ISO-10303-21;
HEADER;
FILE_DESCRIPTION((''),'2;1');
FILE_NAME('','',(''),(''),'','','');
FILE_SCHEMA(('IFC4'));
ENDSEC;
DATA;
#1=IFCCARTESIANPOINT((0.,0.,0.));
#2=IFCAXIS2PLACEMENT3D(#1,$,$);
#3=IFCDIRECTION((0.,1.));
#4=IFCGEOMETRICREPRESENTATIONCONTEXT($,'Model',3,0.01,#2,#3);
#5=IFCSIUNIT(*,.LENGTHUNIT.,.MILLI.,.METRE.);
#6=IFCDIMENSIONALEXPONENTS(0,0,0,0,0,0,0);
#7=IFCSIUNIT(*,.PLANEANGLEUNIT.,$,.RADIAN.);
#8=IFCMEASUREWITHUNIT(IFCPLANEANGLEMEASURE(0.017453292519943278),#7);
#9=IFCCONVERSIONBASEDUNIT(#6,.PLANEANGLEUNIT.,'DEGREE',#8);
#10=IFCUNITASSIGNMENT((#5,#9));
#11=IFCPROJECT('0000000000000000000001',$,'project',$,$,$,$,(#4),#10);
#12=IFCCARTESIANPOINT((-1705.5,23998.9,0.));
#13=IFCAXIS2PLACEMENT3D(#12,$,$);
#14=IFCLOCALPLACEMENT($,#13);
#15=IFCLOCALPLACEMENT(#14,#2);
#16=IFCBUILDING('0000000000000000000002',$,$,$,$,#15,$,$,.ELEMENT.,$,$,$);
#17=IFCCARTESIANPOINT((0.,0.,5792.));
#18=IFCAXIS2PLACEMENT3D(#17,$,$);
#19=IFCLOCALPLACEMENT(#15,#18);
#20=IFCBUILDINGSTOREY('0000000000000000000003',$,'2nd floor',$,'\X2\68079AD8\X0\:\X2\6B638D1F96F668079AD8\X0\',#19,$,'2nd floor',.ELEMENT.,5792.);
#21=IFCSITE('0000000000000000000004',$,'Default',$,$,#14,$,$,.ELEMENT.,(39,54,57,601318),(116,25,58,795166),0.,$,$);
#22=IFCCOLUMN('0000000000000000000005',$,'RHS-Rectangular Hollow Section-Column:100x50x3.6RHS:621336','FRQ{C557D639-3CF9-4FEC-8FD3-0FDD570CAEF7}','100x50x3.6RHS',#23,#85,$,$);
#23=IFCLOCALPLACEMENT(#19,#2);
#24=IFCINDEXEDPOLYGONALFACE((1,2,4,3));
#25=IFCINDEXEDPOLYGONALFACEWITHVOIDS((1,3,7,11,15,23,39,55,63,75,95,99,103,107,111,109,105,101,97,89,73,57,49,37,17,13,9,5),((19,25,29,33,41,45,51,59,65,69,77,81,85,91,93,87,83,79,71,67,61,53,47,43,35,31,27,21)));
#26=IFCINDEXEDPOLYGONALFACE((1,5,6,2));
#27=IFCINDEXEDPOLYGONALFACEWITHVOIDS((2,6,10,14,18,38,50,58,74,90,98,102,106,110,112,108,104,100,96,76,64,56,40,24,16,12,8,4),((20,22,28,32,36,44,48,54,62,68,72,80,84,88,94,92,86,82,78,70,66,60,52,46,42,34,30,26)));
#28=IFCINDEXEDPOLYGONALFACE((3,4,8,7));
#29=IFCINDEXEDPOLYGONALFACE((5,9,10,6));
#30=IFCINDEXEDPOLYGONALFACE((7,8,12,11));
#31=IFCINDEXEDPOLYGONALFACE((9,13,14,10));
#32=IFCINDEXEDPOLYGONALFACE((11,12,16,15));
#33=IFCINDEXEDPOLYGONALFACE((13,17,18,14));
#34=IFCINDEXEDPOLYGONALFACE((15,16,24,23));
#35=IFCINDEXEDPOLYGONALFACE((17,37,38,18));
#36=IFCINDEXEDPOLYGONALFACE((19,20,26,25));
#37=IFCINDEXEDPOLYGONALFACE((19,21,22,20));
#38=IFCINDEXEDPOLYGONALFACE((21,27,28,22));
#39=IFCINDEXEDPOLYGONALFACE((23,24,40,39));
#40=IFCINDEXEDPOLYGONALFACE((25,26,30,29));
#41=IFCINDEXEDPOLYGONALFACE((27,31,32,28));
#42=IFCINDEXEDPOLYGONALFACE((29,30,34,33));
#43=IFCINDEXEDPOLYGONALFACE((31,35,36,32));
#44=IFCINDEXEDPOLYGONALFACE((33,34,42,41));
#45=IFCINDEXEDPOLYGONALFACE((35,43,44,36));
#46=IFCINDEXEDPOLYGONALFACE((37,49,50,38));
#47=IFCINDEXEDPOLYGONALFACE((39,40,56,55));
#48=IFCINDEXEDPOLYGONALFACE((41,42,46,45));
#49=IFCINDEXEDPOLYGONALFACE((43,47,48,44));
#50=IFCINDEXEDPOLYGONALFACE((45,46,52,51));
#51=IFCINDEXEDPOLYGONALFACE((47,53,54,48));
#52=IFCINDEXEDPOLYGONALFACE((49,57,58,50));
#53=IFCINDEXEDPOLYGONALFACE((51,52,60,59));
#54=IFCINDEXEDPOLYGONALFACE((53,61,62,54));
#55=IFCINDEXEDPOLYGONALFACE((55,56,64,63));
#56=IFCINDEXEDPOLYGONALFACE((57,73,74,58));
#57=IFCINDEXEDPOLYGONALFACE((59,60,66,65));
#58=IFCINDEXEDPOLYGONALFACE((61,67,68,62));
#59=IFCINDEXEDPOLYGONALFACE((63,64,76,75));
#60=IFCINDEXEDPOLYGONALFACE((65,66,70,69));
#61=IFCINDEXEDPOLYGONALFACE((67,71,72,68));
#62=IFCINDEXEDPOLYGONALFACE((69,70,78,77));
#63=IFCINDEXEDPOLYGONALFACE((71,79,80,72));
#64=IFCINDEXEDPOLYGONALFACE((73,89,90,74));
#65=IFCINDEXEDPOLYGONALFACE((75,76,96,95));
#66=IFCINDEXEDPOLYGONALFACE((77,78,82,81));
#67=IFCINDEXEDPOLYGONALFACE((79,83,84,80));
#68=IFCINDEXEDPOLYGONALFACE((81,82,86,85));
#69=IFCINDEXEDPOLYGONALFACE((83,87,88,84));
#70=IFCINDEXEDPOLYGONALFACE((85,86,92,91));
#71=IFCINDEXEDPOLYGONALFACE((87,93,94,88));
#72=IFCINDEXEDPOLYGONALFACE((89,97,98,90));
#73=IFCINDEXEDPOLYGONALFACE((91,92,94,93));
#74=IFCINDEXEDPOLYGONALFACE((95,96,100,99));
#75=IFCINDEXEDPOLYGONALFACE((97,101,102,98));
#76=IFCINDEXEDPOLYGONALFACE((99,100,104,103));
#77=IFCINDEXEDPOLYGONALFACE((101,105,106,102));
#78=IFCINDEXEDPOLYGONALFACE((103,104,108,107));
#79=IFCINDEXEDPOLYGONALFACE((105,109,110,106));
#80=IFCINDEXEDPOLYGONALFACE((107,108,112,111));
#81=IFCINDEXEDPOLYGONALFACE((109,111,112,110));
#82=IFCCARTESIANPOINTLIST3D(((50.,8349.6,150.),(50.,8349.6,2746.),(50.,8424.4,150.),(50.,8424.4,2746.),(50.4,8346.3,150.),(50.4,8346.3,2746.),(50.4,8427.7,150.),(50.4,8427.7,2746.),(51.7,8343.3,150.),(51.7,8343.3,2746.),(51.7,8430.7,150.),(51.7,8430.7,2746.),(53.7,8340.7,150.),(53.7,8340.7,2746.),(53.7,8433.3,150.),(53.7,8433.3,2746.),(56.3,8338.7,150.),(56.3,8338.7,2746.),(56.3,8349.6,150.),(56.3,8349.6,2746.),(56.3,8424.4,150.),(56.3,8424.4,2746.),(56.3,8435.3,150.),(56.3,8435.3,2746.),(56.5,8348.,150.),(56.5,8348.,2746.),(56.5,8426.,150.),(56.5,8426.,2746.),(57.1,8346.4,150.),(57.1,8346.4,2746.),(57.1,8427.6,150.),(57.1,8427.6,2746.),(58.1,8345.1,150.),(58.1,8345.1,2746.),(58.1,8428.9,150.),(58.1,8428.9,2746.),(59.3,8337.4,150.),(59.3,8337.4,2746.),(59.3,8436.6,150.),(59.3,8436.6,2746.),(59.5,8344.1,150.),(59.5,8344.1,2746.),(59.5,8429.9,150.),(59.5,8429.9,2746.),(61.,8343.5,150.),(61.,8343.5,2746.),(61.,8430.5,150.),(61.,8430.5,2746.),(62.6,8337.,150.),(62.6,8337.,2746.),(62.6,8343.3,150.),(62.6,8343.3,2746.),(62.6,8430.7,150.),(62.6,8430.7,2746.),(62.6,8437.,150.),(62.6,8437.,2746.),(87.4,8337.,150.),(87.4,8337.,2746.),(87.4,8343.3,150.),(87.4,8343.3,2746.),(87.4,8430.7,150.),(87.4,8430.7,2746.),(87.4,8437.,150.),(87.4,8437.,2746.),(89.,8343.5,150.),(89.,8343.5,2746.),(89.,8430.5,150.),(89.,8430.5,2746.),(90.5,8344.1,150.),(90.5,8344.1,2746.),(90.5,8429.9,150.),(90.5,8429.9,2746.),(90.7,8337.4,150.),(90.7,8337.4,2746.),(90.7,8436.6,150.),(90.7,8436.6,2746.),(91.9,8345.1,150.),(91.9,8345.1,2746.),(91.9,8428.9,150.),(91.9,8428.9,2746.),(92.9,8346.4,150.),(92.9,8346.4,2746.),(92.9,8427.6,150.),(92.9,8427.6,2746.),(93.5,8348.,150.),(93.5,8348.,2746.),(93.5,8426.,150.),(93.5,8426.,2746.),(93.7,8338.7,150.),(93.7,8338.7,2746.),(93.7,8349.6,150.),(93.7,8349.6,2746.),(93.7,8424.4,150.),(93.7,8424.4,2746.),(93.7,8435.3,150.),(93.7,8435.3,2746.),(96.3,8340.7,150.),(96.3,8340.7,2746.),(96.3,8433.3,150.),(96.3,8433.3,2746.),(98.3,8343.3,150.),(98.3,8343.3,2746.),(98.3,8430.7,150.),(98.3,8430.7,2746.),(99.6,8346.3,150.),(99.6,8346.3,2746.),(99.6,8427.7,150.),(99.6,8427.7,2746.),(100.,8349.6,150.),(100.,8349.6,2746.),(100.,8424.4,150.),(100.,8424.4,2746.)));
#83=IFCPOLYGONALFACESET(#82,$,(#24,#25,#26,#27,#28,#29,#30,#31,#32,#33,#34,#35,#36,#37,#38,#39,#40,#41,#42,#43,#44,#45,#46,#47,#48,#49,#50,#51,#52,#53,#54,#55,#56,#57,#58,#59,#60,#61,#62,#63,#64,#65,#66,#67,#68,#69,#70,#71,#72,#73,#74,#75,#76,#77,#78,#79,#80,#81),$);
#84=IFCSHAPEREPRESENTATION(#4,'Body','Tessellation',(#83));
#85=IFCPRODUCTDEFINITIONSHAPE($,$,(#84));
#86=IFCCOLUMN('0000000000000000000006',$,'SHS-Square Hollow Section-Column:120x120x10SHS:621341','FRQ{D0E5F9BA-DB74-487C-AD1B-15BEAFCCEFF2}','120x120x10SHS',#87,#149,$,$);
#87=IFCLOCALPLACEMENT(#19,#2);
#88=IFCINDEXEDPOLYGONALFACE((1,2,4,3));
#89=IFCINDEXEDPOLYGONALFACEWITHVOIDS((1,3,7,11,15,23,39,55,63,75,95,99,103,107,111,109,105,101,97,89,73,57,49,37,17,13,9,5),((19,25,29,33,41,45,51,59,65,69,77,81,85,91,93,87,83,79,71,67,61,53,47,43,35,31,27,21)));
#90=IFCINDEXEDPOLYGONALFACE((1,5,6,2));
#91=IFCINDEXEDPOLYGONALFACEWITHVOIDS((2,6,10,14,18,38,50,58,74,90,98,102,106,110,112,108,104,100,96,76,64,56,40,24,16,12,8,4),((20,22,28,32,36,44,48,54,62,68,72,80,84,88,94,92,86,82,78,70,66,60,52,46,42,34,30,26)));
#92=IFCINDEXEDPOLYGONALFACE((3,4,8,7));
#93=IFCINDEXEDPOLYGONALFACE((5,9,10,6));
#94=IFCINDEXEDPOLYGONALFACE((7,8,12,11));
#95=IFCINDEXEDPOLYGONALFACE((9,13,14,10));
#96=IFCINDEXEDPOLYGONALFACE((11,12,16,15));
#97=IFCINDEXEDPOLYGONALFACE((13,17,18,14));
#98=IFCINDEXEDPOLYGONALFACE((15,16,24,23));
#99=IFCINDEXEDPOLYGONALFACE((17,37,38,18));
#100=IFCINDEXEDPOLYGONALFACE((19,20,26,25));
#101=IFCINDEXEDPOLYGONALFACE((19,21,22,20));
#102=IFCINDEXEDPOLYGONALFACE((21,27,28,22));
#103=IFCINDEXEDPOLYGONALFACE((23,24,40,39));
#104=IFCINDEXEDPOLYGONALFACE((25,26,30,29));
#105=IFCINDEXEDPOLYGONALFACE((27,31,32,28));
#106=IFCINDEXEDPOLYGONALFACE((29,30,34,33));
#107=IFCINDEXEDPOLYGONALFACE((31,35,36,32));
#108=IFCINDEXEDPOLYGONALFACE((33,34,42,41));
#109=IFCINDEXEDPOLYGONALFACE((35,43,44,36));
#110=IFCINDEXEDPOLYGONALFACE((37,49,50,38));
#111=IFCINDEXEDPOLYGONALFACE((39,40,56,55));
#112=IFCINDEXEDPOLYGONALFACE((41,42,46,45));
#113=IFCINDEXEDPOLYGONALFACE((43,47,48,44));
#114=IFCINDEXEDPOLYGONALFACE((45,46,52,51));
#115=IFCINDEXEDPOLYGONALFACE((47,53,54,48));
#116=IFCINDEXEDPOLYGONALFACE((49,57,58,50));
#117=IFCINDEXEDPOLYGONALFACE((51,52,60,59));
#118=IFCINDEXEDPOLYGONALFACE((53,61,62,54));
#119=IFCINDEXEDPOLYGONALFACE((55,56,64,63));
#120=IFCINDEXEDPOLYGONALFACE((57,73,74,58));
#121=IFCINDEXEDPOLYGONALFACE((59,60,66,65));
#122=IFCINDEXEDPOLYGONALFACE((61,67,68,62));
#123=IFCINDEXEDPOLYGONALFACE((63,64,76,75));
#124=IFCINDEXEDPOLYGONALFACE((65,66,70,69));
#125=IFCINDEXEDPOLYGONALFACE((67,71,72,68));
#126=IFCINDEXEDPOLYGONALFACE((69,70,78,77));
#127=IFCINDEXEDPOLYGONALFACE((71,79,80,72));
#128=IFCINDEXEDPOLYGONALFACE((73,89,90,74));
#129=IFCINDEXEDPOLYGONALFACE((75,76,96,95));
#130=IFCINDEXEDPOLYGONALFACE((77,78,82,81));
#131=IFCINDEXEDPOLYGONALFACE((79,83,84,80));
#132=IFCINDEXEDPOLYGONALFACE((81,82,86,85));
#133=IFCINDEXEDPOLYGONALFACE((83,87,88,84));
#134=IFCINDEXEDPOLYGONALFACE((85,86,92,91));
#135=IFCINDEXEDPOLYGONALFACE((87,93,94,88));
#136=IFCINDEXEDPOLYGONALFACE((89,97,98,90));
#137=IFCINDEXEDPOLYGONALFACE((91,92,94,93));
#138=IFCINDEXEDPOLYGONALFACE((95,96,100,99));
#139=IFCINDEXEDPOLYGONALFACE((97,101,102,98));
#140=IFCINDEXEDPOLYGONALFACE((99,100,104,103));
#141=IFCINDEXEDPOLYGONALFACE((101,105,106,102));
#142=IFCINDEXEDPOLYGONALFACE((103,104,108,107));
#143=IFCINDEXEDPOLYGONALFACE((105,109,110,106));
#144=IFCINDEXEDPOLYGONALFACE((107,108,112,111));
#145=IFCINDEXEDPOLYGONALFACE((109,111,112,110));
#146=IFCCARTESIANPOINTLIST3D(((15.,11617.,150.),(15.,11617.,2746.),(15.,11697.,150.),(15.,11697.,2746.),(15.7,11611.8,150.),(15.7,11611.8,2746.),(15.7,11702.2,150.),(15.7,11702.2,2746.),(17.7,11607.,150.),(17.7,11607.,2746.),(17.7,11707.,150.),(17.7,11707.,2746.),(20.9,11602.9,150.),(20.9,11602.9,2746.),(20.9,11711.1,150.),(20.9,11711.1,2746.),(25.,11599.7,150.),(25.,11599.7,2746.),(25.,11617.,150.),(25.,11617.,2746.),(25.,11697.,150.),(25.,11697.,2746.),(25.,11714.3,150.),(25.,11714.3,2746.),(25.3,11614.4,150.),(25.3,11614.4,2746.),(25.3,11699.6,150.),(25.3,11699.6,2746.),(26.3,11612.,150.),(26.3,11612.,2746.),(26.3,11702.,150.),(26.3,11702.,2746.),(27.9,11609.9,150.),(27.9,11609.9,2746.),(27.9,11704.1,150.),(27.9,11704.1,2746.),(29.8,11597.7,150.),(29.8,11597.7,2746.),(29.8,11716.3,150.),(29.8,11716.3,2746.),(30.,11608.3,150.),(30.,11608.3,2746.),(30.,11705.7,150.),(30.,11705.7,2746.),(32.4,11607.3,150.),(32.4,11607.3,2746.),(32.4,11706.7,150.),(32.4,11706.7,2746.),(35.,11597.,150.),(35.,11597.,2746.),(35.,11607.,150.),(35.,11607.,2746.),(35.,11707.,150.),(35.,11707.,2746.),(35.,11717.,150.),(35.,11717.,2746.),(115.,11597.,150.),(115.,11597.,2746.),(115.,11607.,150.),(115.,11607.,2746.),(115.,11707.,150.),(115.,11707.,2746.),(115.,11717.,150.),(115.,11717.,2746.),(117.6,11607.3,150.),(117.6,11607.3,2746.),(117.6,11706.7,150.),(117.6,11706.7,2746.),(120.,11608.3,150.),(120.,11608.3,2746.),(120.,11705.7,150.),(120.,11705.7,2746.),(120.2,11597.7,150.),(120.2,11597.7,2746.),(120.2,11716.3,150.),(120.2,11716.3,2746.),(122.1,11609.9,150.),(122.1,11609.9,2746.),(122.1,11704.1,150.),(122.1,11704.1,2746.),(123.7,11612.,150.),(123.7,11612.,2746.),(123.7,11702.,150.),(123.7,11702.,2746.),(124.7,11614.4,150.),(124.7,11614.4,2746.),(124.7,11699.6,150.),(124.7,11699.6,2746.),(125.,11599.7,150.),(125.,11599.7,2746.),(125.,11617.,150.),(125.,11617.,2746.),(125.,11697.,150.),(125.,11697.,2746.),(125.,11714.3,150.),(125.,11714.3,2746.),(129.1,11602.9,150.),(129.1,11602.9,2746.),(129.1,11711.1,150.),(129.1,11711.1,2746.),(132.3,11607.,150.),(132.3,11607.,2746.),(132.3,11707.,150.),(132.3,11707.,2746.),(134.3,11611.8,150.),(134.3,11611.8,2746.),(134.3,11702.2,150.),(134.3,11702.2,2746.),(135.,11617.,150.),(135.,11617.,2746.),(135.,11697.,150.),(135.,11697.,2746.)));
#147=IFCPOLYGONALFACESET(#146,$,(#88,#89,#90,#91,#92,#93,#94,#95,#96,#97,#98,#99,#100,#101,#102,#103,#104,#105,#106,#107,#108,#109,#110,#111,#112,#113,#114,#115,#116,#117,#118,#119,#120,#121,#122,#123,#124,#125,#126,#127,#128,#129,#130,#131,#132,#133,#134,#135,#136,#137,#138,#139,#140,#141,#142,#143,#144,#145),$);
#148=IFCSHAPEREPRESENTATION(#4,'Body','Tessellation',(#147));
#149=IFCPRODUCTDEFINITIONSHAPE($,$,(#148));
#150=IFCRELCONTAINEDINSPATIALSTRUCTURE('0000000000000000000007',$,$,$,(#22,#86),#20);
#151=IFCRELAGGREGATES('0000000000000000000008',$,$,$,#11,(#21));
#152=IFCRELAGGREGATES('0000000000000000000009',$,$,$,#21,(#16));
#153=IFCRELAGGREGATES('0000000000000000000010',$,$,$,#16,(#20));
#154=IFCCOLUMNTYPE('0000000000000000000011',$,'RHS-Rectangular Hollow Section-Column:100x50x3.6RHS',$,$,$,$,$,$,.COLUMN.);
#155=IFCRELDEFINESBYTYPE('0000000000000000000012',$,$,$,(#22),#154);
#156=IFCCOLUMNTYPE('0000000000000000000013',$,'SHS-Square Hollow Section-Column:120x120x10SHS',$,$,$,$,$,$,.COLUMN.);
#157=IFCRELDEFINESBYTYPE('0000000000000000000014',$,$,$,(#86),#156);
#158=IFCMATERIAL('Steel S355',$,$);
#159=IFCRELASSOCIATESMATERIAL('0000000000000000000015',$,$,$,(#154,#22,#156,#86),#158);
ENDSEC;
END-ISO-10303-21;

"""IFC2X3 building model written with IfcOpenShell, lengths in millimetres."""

from ifc_helpers import new_model, entity, si_unit, converted_unit, direction, frame, origin, origin_2d, place, context, project, spatial, hollow_rectangle, extrude, clip, halfspace, material, type_object, element, save


model = new_model("IFC2X3")

# Units and contexts
model_context = context("Model", 3, precision=0.01, world=origin(), true_north=direction((0.0, 1.0)))
ifc_project = project(units=[si_unit("LENGTHUNIT", "METRE", prefix="MILLI"), converted_unit("PLANEANGLEUNIT", "DEGREE", entity("IfcPlaneAngleMeasure", 0.017453292519943278), si_unit("PLANEANGLEUNIT", "RADIAN"), dimensions=[0, 0, 0, 0, 0, 0, 0])], contexts=[model_context])

# Site, building, storey
site_placement = place(None, frame((-1705.5, 23998.9, 0.0)))
site = spatial("IfcSite", under=ifc_project, at=site_placement, Name="Default", CompositionType="ELEMENT", RefLatitude=(39, 54, 57, 601318), RefLongitude=(116, 25, 58, 795166), RefElevation=0.0)
building_placement = place(site_placement, origin())
building = spatial("IfcBuilding", under=site, at=building_placement, CompositionType="ELEMENT")
storey_placement = place(building_placement, frame((0.0, 0.0, 5792.0)))
storey = spatial("IfcBuildingStorey", under=building, at=storey_placement, Name="2nd floor", ObjectType="标高:正负零标高", LongName="2nd floor", CompositionType="ELEMENT", Elevation=5792.0)

# Columns
ifc_material_1 = material(Name="Steel S355")
column_type_1 = type_object("IfcColumnType", Name="RHS-Rectangular Hollow Section-Column:100x50x3.6RHS", PredefinedType="COLUMN", material=ifc_material_1)
column_1_placement = place(storey_placement, frame((75.0, 8387.0, 2746.0), z_axis=(0.0, 0.0, 1.0), x_axis=(-1.0, 0.0, 0.0)))
element("IfcColumn", 1, at=column_1_placement, inside=storey, type_object=column_type_1, material=ifc_material_1, Name="RHS-Rectangular Hollow Section-Column:100x50x3.6RHS:621336", Description="FRQ{C557D639-3CF9-4FEC-8FD3-0FDD570CAEF7}", ObjectType="100x50x3.6RHS", context=model_context, shape_type="Clipping", body=[
    clip(extrude(hollow_rectangle(XDim=50.0, YDim=100.0, WallThickness=6.3, InnerFilletRadius=6.3, OuterFilletRadius=12.6, at=origin_2d()), origin(), (0.0, 0.0, -1.0), 2651.9), halfspace(frame((75.0, 8387.0, -2596.0), z_axis=(0.0, 0.0, 1.0), x_axis=(-1.0, 0.0, 0.0)), True)),
])
column_type_2 = type_object("IfcColumnType", Name="SHS-Square Hollow Section-Column:120x120x10SHS", PredefinedType="COLUMN", material=ifc_material_1)
column_2_placement = place(storey_placement, frame((75.0, 11657.0, 2830.9), z_axis=(0.0, 0.0, 1.0), x_axis=(0.0, -1.0, 0.0)))
element("IfcColumn", 2, at=column_2_placement, inside=storey, type_object=column_type_2, material=ifc_material_1, Name="SHS-Square Hollow Section-Column:120x120x10SHS:621341", Description="FRQ{D0E5F9BA-DB74-487C-AD1B-15BEAFCCEFF2}", ObjectType="120x120x10SHS", context=model_context, shape_type="Clipping", body=[
    clip(clip(extrude(hollow_rectangle(XDim=120.0, YDim=120.0, WallThickness=10.0, InnerFilletRadius=10.0, OuterFilletRadius=20.0, at=origin_2d()), origin(), (0.0, 0.0, -1.0), 2765.7), halfspace(frame((11657.0, -75.0, -84.9), z_axis=(0.0, 0.0, -1.0), x_axis=(0.0, -1.0, 0.0)), True)), halfspace(frame((11657.0, -75.0, -2680.9), z_axis=(0.0, 0.0, 1.0), x_axis=(0.0, 1.0, 0.0)), True)),
])

save(model, "model.ifc")
